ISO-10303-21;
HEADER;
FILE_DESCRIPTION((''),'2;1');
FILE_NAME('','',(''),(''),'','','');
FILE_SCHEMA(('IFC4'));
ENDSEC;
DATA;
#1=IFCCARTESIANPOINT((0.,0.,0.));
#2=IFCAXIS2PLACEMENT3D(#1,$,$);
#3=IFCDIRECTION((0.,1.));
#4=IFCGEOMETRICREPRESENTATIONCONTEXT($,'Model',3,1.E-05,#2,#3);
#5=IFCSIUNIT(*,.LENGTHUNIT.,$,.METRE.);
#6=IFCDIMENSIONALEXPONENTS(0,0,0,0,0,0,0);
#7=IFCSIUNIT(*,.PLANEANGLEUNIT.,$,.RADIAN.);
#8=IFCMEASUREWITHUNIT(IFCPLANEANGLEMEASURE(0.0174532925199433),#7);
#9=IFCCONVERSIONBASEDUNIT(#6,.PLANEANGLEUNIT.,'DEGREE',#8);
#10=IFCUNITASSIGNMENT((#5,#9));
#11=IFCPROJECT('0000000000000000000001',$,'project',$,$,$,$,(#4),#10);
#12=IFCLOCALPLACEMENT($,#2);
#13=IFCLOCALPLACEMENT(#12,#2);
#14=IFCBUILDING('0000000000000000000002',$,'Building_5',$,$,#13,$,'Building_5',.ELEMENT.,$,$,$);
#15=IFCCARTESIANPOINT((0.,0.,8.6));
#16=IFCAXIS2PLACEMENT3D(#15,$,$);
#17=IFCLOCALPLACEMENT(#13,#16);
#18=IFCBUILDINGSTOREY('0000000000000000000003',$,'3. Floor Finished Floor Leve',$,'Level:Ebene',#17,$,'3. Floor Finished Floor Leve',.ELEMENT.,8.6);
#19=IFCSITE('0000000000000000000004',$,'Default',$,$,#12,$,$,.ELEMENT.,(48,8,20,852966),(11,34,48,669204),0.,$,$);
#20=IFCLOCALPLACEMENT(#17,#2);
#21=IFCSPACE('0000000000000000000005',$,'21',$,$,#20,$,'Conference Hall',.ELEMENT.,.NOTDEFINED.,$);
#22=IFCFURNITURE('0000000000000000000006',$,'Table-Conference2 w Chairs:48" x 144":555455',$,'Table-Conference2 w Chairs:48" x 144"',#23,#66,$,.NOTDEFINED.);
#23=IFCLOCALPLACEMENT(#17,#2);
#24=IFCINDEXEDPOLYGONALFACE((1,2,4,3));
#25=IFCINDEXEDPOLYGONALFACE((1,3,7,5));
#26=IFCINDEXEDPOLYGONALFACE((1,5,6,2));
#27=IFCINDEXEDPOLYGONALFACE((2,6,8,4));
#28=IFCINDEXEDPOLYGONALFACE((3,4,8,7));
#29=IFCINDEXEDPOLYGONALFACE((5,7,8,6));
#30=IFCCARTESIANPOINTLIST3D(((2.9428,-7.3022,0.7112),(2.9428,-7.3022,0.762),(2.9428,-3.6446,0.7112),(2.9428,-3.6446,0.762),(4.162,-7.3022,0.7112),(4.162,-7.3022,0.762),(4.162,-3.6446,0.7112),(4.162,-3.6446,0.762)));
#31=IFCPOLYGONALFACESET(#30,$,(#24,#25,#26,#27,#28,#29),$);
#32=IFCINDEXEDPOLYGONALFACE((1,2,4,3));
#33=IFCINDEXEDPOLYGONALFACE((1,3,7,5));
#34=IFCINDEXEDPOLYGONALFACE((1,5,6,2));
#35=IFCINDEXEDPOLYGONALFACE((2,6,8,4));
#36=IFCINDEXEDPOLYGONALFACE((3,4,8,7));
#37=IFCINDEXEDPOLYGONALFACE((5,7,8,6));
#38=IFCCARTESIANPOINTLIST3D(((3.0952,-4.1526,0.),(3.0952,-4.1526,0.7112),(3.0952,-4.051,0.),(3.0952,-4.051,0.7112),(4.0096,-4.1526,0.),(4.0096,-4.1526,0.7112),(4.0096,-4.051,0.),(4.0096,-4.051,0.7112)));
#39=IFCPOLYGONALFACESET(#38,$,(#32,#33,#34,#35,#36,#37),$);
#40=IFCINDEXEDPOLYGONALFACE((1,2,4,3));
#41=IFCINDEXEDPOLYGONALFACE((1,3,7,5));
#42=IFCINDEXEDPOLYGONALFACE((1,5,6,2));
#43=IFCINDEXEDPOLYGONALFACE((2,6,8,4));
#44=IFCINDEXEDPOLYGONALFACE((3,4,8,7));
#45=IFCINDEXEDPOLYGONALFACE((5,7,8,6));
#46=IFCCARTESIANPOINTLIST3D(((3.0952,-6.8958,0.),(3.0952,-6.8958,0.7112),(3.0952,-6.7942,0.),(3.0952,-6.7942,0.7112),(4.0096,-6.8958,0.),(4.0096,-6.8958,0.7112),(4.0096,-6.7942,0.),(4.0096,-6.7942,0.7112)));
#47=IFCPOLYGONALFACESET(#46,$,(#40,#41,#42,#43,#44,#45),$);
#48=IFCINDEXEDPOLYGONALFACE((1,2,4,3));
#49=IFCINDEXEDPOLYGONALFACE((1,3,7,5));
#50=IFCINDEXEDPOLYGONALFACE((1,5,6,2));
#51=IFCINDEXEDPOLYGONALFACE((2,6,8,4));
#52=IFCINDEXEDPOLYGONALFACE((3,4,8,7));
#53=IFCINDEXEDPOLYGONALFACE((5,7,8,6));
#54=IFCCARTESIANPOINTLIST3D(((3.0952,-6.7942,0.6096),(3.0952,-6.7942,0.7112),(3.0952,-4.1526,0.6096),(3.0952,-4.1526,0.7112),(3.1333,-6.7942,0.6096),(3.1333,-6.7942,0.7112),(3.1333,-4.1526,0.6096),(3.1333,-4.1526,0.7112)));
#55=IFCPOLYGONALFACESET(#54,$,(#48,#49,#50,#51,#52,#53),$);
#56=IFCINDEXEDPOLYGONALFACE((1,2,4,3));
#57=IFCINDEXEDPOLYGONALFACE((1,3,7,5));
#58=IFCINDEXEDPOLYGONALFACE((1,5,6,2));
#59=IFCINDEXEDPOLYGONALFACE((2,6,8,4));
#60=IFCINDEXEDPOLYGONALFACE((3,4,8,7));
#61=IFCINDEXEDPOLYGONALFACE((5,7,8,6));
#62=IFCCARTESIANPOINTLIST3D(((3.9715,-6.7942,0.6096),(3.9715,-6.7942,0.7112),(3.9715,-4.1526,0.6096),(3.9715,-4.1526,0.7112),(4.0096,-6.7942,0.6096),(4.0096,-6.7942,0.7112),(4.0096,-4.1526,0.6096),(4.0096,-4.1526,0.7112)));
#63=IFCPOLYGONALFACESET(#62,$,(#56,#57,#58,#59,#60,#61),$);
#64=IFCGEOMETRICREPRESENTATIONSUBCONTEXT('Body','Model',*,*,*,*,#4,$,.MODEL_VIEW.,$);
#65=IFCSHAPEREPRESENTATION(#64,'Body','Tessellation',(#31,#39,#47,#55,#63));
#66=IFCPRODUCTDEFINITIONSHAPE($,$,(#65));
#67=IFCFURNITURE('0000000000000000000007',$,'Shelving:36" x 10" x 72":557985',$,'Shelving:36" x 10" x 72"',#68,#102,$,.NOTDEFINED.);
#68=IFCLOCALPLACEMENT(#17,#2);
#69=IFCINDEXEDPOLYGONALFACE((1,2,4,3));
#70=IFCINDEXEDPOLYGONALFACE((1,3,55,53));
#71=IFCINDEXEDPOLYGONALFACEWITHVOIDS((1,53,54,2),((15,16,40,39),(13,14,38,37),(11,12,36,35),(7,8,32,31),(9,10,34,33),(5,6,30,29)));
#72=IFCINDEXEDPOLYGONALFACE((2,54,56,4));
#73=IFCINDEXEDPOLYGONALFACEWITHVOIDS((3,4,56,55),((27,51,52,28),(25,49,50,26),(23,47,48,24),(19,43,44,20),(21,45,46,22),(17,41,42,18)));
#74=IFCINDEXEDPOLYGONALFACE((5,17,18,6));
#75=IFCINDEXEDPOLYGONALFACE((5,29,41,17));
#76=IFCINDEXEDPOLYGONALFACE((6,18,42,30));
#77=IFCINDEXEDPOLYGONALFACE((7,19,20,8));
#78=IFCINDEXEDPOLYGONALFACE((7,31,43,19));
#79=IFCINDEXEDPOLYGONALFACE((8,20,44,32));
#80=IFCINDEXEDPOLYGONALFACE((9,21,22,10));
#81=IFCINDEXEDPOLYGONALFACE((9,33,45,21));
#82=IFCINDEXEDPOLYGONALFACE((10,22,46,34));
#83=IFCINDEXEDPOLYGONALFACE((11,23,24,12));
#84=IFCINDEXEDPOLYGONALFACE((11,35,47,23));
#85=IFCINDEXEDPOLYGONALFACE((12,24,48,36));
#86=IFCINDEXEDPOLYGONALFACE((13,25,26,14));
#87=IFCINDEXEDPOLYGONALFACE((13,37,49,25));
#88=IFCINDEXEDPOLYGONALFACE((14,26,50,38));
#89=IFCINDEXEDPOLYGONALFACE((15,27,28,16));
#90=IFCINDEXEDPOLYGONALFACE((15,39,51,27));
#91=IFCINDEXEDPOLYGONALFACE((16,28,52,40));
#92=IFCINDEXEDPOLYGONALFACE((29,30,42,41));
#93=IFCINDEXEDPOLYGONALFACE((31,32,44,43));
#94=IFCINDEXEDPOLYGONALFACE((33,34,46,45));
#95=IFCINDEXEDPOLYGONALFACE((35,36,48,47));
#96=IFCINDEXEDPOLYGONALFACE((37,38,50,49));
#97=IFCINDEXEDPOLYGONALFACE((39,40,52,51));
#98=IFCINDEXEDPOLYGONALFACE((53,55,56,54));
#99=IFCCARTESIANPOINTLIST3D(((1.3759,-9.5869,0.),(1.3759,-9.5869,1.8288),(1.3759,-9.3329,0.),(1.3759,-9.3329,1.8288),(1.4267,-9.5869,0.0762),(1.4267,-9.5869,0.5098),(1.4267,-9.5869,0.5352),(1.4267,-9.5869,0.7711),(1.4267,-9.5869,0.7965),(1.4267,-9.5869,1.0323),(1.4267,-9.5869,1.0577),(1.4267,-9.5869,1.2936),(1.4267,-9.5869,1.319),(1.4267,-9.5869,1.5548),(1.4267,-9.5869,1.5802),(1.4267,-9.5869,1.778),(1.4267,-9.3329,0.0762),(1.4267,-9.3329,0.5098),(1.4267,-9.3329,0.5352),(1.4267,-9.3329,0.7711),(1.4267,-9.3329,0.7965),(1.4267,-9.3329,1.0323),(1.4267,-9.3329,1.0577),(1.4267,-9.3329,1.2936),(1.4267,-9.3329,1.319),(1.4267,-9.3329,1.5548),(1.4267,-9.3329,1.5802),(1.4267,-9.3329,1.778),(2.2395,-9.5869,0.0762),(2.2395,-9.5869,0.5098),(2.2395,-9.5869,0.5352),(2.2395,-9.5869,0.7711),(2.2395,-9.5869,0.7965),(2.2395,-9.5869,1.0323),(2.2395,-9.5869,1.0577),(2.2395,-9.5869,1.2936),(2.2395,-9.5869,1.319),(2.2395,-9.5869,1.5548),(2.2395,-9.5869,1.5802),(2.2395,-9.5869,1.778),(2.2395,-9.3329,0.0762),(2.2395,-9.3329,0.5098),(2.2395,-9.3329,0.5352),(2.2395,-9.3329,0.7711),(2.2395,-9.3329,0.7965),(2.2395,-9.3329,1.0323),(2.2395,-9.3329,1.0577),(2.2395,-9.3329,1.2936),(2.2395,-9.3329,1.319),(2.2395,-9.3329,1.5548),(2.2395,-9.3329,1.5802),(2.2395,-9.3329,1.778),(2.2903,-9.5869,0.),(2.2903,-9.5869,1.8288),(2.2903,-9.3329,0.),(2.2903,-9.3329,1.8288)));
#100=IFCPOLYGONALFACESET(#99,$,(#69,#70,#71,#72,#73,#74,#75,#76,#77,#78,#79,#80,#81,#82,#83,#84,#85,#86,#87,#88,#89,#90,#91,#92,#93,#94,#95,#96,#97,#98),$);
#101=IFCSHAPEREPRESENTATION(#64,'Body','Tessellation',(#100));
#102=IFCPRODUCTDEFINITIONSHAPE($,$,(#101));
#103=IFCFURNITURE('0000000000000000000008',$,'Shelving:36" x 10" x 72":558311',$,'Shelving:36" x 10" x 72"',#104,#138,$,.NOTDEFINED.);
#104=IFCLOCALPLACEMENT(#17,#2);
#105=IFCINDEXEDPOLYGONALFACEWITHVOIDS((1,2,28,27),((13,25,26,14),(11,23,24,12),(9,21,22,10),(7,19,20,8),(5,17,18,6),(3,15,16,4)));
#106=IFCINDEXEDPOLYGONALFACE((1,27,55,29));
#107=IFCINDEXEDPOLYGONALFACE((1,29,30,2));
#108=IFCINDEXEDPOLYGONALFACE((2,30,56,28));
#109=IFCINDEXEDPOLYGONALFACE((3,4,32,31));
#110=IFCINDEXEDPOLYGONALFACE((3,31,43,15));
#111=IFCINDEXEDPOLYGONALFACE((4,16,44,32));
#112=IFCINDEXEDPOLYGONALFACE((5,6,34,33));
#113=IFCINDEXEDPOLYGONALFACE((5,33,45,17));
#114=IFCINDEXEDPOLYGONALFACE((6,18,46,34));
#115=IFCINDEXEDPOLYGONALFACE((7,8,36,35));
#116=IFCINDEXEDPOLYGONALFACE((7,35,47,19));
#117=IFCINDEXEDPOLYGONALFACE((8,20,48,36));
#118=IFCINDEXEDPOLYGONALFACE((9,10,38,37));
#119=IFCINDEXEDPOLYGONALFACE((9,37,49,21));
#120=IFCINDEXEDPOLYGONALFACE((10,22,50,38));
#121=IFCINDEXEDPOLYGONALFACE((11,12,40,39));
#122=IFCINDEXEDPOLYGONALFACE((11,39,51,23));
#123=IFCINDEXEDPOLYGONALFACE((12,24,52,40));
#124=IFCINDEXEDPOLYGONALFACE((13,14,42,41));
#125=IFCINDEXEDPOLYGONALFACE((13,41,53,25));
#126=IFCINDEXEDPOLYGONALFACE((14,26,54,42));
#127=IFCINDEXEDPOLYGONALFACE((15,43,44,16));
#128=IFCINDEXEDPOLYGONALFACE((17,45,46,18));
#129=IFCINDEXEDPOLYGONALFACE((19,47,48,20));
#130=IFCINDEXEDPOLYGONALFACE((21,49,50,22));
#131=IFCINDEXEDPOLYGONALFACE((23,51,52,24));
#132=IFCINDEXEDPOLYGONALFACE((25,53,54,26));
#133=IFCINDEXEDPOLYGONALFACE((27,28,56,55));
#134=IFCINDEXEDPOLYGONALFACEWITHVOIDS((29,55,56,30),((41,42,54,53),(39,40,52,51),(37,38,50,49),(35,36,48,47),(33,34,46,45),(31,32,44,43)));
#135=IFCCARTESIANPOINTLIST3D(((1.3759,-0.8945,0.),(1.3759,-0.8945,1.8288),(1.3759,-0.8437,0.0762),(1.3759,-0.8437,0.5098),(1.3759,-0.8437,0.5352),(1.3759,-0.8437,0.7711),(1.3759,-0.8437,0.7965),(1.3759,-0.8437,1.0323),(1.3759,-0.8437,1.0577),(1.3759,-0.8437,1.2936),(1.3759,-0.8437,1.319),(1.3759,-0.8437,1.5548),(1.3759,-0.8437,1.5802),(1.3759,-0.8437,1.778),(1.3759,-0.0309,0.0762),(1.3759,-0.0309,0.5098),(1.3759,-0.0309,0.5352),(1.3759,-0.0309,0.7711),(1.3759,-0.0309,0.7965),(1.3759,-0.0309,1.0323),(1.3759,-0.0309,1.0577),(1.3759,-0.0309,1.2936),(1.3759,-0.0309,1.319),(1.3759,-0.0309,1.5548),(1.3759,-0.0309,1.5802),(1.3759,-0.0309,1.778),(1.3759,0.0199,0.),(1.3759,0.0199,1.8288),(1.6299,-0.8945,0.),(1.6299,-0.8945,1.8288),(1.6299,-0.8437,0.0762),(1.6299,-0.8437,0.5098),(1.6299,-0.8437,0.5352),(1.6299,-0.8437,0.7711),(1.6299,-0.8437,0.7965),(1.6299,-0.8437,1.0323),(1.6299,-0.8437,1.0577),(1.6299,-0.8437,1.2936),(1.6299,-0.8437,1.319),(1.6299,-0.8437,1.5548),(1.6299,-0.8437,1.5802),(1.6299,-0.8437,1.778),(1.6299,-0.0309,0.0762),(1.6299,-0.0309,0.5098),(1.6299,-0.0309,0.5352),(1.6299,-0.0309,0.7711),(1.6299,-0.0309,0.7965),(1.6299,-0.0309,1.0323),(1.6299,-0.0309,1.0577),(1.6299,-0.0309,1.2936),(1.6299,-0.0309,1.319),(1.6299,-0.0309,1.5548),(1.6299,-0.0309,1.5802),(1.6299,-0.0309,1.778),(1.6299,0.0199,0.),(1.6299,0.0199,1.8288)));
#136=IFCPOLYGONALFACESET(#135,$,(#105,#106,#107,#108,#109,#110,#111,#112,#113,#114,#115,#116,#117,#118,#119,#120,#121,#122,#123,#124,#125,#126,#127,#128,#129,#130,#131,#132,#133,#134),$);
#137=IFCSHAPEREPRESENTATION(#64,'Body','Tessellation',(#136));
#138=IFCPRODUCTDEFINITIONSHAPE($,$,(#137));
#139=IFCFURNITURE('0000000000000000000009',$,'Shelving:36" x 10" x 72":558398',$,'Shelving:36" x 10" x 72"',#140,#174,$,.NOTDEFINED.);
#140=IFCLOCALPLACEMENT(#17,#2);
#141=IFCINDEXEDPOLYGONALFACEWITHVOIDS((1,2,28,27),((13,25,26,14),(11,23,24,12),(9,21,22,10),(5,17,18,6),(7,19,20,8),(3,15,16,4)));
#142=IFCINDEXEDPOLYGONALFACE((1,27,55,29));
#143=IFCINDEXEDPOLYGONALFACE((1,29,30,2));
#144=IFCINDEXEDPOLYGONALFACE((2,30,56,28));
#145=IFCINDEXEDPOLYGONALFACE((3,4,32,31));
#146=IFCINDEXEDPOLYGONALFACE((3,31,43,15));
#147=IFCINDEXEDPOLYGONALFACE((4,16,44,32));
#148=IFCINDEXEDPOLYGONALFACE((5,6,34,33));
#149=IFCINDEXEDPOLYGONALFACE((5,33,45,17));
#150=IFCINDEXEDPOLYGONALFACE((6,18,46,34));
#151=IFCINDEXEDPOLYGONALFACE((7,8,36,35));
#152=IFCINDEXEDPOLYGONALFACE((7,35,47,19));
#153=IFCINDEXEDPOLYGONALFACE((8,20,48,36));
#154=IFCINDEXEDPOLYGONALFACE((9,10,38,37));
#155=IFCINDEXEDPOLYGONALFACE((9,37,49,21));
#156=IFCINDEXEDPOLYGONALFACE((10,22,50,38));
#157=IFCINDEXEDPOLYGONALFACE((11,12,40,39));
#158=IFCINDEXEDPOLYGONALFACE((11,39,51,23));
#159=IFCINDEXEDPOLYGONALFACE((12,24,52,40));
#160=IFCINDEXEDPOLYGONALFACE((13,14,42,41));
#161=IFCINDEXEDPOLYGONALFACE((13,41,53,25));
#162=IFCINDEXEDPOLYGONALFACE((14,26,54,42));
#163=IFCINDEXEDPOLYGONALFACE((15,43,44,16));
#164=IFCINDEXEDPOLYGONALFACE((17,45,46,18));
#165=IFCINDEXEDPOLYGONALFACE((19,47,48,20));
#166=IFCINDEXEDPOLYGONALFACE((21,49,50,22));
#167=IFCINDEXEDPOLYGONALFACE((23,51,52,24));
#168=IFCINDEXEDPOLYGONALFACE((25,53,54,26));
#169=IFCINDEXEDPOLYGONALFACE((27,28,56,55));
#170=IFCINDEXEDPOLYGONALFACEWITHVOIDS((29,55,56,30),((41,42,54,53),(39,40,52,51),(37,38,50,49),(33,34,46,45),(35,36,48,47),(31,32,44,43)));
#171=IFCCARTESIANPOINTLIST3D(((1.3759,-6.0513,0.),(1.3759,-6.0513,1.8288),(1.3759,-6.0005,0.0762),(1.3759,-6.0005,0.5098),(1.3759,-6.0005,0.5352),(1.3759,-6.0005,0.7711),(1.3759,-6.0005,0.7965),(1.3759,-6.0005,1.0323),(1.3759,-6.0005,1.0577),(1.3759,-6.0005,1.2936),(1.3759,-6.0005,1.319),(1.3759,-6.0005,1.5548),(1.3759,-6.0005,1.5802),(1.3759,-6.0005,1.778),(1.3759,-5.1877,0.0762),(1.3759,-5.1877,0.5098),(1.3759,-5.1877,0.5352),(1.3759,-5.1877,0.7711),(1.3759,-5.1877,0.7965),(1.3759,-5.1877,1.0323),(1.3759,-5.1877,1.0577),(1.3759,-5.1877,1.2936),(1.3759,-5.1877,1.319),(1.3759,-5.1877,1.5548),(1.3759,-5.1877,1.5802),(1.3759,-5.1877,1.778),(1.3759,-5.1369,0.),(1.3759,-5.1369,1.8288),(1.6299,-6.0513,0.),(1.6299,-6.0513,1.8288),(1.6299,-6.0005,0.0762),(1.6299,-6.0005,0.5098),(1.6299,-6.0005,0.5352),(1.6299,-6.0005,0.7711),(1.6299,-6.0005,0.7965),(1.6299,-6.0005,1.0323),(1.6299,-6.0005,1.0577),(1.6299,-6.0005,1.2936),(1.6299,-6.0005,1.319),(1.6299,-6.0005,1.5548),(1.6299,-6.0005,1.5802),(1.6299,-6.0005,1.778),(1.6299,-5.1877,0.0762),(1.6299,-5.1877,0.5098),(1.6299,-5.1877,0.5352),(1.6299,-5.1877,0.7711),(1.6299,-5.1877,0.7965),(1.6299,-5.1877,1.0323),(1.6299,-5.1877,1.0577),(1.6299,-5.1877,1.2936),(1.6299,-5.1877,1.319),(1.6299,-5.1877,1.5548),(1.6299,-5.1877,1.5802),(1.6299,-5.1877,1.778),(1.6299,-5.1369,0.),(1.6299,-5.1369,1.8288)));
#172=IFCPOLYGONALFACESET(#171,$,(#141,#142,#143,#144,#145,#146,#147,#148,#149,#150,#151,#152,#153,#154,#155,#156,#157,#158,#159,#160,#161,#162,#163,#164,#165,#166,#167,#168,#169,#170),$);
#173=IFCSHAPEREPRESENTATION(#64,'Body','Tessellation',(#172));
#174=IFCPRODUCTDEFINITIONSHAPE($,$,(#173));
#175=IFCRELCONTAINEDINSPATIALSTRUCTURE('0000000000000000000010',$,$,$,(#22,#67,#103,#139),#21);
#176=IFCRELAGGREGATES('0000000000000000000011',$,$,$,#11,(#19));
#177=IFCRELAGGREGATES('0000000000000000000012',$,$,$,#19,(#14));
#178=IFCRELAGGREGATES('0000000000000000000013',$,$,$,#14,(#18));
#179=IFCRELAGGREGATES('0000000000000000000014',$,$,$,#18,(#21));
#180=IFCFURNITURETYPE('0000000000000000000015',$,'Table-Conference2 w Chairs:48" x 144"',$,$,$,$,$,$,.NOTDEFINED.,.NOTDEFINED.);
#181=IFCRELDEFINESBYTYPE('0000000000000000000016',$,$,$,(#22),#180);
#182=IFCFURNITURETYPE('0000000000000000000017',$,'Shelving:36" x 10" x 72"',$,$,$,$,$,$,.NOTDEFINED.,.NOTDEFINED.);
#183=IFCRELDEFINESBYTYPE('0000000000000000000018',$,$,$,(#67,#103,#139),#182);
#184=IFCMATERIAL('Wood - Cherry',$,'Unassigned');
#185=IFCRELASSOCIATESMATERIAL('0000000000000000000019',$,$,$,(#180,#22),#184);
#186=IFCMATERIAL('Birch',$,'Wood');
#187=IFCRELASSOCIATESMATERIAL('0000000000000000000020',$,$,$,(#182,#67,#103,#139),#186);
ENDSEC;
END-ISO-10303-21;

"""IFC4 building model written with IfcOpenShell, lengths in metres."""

from ifc_helpers import new_model, entity, si_unit, converted_unit, direction, frame, origin, place, context, subcontext, project, spatial, indexed_curve, outline, extrude, source, transform, mapped, material, type_object, type_shapes, element, save


model = new_model("IFC4")

# Units and contexts
model_context = context("Model", 3, precision=1e-05, world=origin(), true_north=direction((0.0, 1.0)))
body_context = subcontext(model_context, "Body", "Model", "MODEL_VIEW")
ifc_project = project(units=[si_unit("LENGTHUNIT", "METRE"), converted_unit("PLANEANGLEUNIT", "DEGREE", entity("IfcPlaneAngleMeasure", 0.0174532925199433), si_unit("PLANEANGLEUNIT", "RADIAN"), dimensions=[0, 0, 0, 0, 0, 0, 0])], contexts=[model_context])

# Site, building, storey
site_placement = place(None, origin())
site = spatial("IfcSite", under=ifc_project, at=site_placement, Name="Default", CompositionType="ELEMENT", RefLatitude=(48, 8, 20, 852966), RefLongitude=(11, 34, 48, 669204), RefElevation=0.0)
building_placement = place(site_placement, origin())
building = spatial("IfcBuilding", under=site, at=building_placement, Name="Building_5", LongName="Building_5", CompositionType="ELEMENT")
storey_placement = place(building_placement, frame((0.0, 0.0, 8.6)))
storey = spatial("IfcBuildingStorey", under=building, at=storey_placement, Name="3. Floor Finished Floor Leve", ObjectType="Level:Ebene", LongName="3. Floor Finished Floor Leve", CompositionType="ELEMENT", Elevation=8.6)

# Shared definitions
space_placement = place(storey_placement, origin())
space = spatial("IfcSpace", under=storey, at=space_placement, Name="21", LongName="Conference Hall", CompositionType="ELEMENT", PredefinedType="NOTDEFINED")

# Furniture
ifc_material_1 = material(Name="Wood - Cherry", Category="Unassigned")
furniture_type_1 = type_object("IfcFurnitureType", Name="Table-Conference2 w Chairs:48\" x 144\"", AssemblyPlace="NOTDEFINED", PredefinedType="NOTDEFINED", material=ifc_material_1)
shared_shape_1 = source(origin(), body_context, "Body", "SweptSolid", [
    extrude(outline(indexed_curve([(-0.6096, -1.8288), (0.6096, -1.8288), (0.6096, 1.8288), (-0.6096, 1.8288), (-0.6096, -1.8288)], self_intersect=False)), frame((0.0, 0.0, 0.7112), z_axis=(0.0, 0.0, 1.0), x_axis=(0.0, 1.0, 0.0)), (0.0, 0.0, 1.0), 0.0508),
    extrude(outline(indexed_curve([(-0.4572, -0.0508), (0.4572, -0.0508), (0.4572, 0.0508), (-0.4572, 0.0508), (-0.4572, -0.0508)], self_intersect=False)), frame((1.3716, 0.0, 0.0), z_axis=(0.0, 0.0, 1.0), x_axis=(0.0, 1.0, 0.0)), (0.0, 0.0, 1.0), 0.7112),
    extrude(outline(indexed_curve([(-0.4572, -0.0508), (0.4572, -0.0508), (0.4572, 0.0508), (-0.4572, 0.0508), (-0.4572, -0.0508)], self_intersect=False)), frame((-1.3716, 0.0, 0.0), z_axis=(0.0, 0.0, 1.0), x_axis=(0.0, 1.0, 0.0)), (0.0, 0.0, 1.0), 0.7112),
    extrude(outline(indexed_curve([(-1.3208, -0.0191), (1.3208, -0.0191), (1.3208, 0.0191), (-1.3208, 0.0191), (-1.3208, -0.0191)], self_intersect=False)), frame((0.0, 0.4382, 0.6096), z_axis=(0.0, 0.0, 1.0), x_axis=(-1.0, 0.0, 0.0)), (0.0, 0.0, 1.0), 0.1016),
    extrude(outline(indexed_curve([(-0.019, -1.3208), (0.019, -1.3208), (0.019, 1.3208), (-0.019, 1.3208), (-0.019, -1.3208)], self_intersect=False)), frame((0.0, -0.4382, 0.6096), z_axis=(0.0, 0.0, 1.0), x_axis=(0.0, 1.0, 0.0)), (0.0, 0.0, 1.0), 0.1016),
])
type_shapes(furniture_type_1, [shared_shape_1])
furniture_1_placement = place(space_placement, frame((3.5524, -5.4734, 0.0), z_axis=(0.0, 0.0, 1.0), x_axis=(0.0, 1.0, 0.0)))
element("IfcFurniture", 1, at=furniture_1_placement, inside=space, type_object=furniture_type_1, material=ifc_material_1, Name="Table-Conference2 w Chairs:48\" x 144\":555455", ObjectType="Table-Conference2 w Chairs:48\" x 144\"", PredefinedType="NOTDEFINED", context=body_context, shape_type="MappedRepresentation", body=[
    mapped(shared_shape_1, transform((0.0, 0.0, 0.0), scale=1.0)),
])
ifc_material_2 = material(Name="Birch", Category="Wood")
furniture_type_2 = type_object("IfcFurnitureType", Name="Shelving:36\" x 10\" x 72\"", AssemblyPlace="NOTDEFINED", PredefinedType="NOTDEFINED", material=ifc_material_2)
shared_shape_2 = source(origin(), body_context, "Body", "SweptSolid", [
    extrude(outline(indexed_curve([(-0.4572, -0.9144), (0.4572, -0.9144), (0.4572, 0.9144), (-0.4572, 0.9144), (-0.4572, -0.9144)], self_intersect=False), holes=[indexed_curve([(-0.4064, 0.8636), (0.4064, 0.8636), (0.4064, 0.6658), (-0.4064, 0.6658), (-0.4064, 0.8636)], self_intersect=False), indexed_curve([(-0.4064, -0.8382), (-0.4064, -0.4046), (0.4064, -0.4046), (0.4064, -0.8382), (-0.4064, -0.8382)], self_intersect=False), indexed_curve([(0.4064, 0.1433), (-0.4064, 0.1433), (-0.4064, 0.3792), (0.4064, 0.3792), (0.4064, 0.1433)], self_intersect=False), indexed_curve([(-0.4064, 0.6404), (0.4064, 0.6404), (0.4064, 0.4046), (-0.4064, 0.4046), (-0.4064, 0.6404)], self_intersect=False), indexed_curve([(-0.4064, 0.1179), (0.4064, 0.1179), (0.4064, -0.1179), (-0.4064, -0.1179), (-0.4064, 0.1179)], self_intersect=False), indexed_curve([(-0.4064, -0.1433), (0.4064, -0.1433), (0.4064, -0.3792), (-0.4064, -0.3792), (-0.4064, -0.1433)], self_intersect=False)]), frame((0.0, -0.4318, 0.9144), z_axis=(0.0, 1.0, 0.0), x_axis=(-1.0, 0.0, 0.0)), (0.0, 0.0, 1.0), 0.254),
])
type_shapes(furniture_type_2, [shared_shape_2])
furniture_2_placement = place(space_placement, frame((1.8331, -9.1551, 0.0)))
element("IfcFurniture", 2, at=furniture_2_placement, inside=space, type_object=furniture_type_2, material=ifc_material_2, Name="Shelving:36\" x 10\" x 72\":557985", ObjectType="Shelving:36\" x 10\" x 72\"", PredefinedType="NOTDEFINED", context=body_context, shape_type="MappedRepresentation", body=[
    mapped(shared_shape_2, transform((0.0, 0.0, 0.0), scale=1.0)),
])
for number, where, z_axis, x_axis, name in (
    (3, (1.8077, -0.4373, 0.0), (0.0, 0.0, 1.0), (0.0, -1.0, 0.0), "Shelving:36\" x 10\" x 72\":558311"),
    (4, (1.8077, -5.5941, 0.0), (0.0, 0.0, 1.0), (0.0, -1.0, 0.0), "Shelving:36\" x 10\" x 72\":558398"),
):
    element("IfcFurniture", number, at=place(space_placement, frame(where, z_axis=z_axis, x_axis=x_axis)), inside=space, type_object=furniture_type_2, material=ifc_material_2, Name=name, ObjectType="Shelving:36\" x 10\" x 72\"", PredefinedType="NOTDEFINED", context=body_context, shape_type="MappedRepresentation", body=[
        mapped(shared_shape_2, transform((0.0, 0.0, 0.0), scale=1.0)),
    ])

save(model, "model.ifc")
